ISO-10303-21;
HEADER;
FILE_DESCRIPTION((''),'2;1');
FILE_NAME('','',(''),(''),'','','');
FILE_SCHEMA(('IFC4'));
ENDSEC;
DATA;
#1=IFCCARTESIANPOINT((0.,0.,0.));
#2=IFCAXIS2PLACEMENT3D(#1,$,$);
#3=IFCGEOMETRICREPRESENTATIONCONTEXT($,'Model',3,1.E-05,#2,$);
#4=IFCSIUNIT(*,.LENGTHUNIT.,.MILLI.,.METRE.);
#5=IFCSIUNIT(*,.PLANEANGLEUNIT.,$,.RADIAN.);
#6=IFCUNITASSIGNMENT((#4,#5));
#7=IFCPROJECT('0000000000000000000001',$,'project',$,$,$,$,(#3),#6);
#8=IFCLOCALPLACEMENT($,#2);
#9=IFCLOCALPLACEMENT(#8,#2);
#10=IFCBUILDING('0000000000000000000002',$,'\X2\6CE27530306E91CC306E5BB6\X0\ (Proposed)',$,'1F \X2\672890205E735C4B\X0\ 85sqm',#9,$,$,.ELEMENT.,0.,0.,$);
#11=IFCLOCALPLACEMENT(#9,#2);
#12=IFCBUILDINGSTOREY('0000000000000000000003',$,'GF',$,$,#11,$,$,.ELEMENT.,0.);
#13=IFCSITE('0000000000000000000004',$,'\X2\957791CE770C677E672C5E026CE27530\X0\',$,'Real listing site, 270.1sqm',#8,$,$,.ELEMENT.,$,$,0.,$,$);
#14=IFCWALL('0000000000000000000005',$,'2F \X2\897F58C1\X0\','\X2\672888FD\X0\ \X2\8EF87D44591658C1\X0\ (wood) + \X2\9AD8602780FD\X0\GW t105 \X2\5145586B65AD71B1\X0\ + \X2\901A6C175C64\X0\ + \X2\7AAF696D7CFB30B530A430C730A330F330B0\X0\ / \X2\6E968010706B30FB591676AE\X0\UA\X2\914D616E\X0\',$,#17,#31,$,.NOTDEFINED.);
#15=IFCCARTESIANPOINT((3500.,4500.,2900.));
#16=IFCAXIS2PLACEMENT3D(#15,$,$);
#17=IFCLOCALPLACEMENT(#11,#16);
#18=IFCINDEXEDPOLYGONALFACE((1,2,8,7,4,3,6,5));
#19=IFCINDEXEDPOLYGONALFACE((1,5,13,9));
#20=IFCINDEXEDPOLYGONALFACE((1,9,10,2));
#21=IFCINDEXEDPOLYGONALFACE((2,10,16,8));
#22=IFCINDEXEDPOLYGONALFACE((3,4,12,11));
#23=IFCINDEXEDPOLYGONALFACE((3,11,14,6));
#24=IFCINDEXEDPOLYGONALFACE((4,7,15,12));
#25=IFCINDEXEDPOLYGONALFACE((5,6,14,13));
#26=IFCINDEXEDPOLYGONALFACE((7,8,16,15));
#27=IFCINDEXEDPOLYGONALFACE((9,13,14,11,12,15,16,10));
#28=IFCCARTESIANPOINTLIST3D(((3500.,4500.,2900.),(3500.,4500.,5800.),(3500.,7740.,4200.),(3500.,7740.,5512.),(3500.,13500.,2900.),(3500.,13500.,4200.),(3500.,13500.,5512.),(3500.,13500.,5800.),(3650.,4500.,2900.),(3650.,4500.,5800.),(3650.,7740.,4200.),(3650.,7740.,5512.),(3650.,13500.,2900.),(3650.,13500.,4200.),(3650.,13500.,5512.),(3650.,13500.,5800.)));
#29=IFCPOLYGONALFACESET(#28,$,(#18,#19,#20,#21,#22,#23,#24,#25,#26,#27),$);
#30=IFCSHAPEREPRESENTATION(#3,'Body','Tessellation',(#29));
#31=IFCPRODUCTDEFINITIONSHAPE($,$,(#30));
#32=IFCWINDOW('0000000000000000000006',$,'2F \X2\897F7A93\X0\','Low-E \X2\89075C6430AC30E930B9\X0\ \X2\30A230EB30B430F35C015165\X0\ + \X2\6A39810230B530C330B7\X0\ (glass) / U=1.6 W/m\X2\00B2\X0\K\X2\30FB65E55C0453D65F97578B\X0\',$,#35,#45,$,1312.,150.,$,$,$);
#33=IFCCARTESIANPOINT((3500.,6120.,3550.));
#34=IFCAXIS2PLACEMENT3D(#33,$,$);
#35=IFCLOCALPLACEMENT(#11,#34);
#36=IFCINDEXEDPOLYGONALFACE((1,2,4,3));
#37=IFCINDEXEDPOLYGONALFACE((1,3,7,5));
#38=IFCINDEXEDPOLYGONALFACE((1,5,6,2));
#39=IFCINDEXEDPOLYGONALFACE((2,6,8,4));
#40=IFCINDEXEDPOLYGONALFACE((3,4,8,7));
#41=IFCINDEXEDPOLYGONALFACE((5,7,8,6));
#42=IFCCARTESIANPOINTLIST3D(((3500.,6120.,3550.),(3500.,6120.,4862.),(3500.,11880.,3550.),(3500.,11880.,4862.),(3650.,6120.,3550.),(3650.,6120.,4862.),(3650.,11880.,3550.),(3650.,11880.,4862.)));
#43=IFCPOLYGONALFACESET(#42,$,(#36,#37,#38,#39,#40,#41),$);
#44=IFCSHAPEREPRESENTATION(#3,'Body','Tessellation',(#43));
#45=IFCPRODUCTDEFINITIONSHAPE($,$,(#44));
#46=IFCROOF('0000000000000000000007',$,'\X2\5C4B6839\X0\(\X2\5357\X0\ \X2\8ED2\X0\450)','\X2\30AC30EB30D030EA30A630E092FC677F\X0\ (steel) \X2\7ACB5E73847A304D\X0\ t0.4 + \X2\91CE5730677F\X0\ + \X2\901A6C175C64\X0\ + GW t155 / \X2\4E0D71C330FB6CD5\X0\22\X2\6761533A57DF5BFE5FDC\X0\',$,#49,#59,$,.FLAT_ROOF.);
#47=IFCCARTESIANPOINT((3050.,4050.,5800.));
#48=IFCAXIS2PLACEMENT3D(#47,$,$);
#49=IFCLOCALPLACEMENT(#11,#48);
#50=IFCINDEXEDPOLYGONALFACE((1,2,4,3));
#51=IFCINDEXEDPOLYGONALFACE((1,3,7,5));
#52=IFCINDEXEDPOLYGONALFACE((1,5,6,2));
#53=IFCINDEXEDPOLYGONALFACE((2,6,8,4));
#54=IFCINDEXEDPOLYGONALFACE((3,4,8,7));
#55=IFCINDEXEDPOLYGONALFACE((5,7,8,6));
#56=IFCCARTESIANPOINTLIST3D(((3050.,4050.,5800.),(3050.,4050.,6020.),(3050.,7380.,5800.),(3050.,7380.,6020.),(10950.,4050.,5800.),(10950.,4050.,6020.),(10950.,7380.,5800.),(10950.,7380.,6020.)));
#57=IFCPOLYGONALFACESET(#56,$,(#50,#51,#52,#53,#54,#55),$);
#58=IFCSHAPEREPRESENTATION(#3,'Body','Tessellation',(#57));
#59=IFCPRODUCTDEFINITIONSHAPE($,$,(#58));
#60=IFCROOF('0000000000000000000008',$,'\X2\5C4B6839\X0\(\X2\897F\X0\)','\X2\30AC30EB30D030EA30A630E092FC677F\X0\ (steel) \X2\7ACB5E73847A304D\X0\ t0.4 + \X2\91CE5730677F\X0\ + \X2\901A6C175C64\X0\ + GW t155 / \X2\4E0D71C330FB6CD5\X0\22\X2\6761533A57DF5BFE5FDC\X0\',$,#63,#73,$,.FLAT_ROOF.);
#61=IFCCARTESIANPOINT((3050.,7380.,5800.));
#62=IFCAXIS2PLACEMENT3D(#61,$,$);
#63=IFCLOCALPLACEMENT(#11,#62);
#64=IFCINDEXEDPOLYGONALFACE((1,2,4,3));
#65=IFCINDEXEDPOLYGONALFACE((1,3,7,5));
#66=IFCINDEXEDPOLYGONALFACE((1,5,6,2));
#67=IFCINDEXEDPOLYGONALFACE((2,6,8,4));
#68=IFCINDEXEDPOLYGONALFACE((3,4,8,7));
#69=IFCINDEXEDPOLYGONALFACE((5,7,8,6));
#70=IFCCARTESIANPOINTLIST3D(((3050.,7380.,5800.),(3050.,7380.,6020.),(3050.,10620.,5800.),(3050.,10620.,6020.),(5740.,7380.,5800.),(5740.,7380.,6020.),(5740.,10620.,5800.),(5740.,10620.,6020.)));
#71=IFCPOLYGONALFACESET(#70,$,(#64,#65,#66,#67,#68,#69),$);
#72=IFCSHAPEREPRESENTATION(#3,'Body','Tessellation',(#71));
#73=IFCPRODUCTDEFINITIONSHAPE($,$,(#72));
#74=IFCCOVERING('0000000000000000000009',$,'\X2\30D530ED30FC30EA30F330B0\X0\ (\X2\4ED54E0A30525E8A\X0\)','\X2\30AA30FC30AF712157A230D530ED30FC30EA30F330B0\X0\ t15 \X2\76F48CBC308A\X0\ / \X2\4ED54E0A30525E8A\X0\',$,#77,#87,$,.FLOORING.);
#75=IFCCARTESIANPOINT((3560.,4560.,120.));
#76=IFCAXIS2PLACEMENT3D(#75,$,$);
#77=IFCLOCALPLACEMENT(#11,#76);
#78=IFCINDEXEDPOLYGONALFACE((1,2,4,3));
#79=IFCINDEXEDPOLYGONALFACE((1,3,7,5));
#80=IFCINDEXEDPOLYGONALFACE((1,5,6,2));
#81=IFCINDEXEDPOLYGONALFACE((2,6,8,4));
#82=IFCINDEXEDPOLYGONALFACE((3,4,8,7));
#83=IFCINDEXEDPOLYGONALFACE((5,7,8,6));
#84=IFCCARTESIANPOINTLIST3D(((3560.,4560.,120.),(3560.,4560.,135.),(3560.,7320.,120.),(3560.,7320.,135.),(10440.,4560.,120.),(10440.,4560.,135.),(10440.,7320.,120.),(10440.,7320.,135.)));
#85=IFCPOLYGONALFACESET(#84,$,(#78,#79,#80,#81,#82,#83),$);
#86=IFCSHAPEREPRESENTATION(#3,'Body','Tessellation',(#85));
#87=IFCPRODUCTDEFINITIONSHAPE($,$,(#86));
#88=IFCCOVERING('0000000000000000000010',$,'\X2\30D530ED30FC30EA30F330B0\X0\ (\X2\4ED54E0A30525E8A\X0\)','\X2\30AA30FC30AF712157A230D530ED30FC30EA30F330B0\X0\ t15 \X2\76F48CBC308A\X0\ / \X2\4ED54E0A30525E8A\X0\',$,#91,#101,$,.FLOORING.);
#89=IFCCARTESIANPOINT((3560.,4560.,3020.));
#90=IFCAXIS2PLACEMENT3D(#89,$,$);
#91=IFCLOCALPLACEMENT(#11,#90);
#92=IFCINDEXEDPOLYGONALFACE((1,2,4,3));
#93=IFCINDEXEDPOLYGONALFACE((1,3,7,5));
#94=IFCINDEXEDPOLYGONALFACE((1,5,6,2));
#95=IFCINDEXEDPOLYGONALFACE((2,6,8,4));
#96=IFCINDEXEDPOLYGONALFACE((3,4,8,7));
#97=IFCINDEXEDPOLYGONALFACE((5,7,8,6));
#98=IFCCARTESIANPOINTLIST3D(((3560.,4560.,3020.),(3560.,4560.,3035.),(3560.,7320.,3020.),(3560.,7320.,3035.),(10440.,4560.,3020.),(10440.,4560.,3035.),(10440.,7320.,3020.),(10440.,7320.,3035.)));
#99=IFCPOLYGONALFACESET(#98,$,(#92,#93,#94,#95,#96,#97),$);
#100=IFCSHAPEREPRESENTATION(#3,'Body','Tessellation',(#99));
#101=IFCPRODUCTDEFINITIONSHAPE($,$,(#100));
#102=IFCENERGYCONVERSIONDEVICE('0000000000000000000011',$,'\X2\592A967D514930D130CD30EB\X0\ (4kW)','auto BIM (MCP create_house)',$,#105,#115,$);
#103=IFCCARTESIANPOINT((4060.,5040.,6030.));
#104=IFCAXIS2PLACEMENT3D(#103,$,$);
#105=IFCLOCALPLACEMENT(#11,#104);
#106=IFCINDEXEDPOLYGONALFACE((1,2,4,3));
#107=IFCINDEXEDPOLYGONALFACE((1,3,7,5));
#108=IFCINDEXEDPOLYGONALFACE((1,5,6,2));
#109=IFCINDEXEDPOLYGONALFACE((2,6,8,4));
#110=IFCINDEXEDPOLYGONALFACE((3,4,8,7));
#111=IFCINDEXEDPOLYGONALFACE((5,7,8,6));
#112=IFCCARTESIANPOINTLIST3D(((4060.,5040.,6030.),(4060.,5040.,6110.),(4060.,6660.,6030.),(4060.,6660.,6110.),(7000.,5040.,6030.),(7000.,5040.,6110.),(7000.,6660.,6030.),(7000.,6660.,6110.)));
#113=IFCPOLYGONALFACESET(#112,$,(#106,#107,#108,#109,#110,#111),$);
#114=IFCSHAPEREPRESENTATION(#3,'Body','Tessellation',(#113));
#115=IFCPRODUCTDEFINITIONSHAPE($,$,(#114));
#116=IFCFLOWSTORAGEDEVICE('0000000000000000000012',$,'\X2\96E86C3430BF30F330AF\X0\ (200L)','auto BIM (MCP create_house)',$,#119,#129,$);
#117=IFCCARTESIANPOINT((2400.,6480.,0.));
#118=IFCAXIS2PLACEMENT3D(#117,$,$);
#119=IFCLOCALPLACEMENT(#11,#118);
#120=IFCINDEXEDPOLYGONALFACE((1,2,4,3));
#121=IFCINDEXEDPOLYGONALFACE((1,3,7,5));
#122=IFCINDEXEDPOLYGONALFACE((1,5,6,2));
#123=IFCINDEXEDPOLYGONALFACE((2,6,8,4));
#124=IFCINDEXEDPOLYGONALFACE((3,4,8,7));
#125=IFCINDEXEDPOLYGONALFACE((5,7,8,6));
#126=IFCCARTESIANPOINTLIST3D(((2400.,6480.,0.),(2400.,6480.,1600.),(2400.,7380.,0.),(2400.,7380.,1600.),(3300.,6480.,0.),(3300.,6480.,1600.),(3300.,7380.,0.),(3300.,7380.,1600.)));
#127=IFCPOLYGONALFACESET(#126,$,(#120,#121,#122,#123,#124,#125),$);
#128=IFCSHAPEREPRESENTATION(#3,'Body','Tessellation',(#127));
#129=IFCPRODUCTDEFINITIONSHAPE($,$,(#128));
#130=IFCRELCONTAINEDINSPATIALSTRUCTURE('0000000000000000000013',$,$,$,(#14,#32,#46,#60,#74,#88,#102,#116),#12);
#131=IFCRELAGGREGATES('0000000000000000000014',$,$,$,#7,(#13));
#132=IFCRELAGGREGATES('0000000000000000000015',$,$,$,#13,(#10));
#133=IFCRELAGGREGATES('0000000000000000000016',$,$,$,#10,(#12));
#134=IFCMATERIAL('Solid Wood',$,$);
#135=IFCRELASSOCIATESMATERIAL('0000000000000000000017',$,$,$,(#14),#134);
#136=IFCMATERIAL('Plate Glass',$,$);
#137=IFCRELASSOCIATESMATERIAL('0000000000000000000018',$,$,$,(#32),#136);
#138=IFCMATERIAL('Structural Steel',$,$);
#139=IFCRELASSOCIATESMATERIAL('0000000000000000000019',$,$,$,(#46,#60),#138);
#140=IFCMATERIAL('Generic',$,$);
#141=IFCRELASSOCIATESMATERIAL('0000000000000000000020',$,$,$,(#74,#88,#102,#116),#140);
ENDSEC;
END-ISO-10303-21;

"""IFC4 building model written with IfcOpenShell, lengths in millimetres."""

from ifc_helpers import new_model, si_unit, frame, frame_2d, origin, place, context, project, spatial, rectangle, extrude, material, element, fill, save


model = new_model("IFC4")

# Units and contexts
model_context = context("Model", 3, precision=1e-05, world=origin())
ifc_project = project(units=[si_unit("LENGTHUNIT", "METRE", prefix="MILLI"), si_unit("PLANEANGLEUNIT", "RADIAN")], contexts=[model_context])

# Site, building, storey
site_placement = place(None, origin())
site = spatial("IfcSite", under=ifc_project, at=site_placement, Name="長野県松本市波田", ObjectType="Real listing site, 270.1sqm", CompositionType="ELEMENT", RefElevation=0.0)
building_placement = place(site_placement, origin())
building = spatial("IfcBuilding", under=site, at=building_placement, Name="波田の里の家 (Proposed)", ObjectType="1F 木造平屋 85sqm", CompositionType="ELEMENT", ElevationOfRefHeight=0.0, ElevationOfTerrain=0.0)
storey_placement = place(building_placement, origin())
storey = spatial("IfcBuildingStorey", under=building, at=storey_placement, Name="GF", CompositionType="ELEMENT", Elevation=0.0)

# Shared definitions
ifc_material_1 = material(Name="Solid Wood")
ifc_material_2 = material(Name="Generic")

# Shared definitions
ifc_material_3 = material(Name="Plate Glass")

# Wall, opening, window
wall_1_placement = place(storey_placement, frame((3500.0, 4500.0, 2900.0)))
wall_1 = element("IfcWall", 1, at=wall_1_placement, inside=storey, material=ifc_material_1, Name="2F 西壁", Description="木製 軸組外壁 (wood) + 高性能GW t105 充填断熱 + 通気層 + 窯業系サイディング / 準耐火・外皮UA配慮", PredefinedType="NOTDEFINED", context=model_context, shape_type="SweptSolid", body=[
    extrude(rectangle(XDim=150.0, YDim=9000.0, at=frame_2d((75.0, 4500.0))), frame((3500.0, 4500.0, 2900.0)), (0.0, 0.0, 1.0), 2900.0),
])
opening_1_placement = place(storey_placement, frame((3500.0, 6120.0, 3550.0)))
opening_1 = element("IfcOpeningElement", 2, at=opening_1_placement, cuts=wall_1, PredefinedType="NOTDEFINED", context=model_context, shape_type="SweptSolid", body=[
    extrude(rectangle(XDim=150.0, YDim=5760.0, at=frame_2d((75.0, 2880.0))), frame((3500.0, 6120.0, 3550.0)), (0.0, 0.0, 1.0), 1312.0),
])
window_1_placement = place(storey_placement, frame((3500.0, 6120.0, 3550.0)))
window_1 = element("IfcWindow", 3, at=window_1_placement, inside=storey, material=ifc_material_3, Name="2F 西窓", Description="Low-E 複層ガラス アルゴン封入 + 樹脂サッシ (glass) / U=1.6 W/m²K・日射取得型", OverallHeight=1312.0, OverallWidth=150.0, context=model_context, shape_type="SweptSolid", body=[
    extrude(rectangle(XDim=150.0, YDim=5760.0, at=frame_2d((75.0, 2880.0))), frame((3500.0, 6120.0, 3550.0)), (0.0, 0.0, 1.0), 1312.0),
])
fill(opening_1, window_1)

# Roofs
ifc_material_4 = material(Name="Structural Steel")
roof_1_placement = place(storey_placement, frame((3050.0, 4050.0, 5800.0)))
element("IfcRoof", 4, at=roof_1_placement, inside=storey, material=ifc_material_4, Name="屋根(南 軒450)", Description="ガルバリウム鋼板 (steel) 立平葺き t0.4 + 野地板 + 通気層 + GW t155 / 不燃・法22条区域対応", PredefinedType="FLAT_ROOF", context=model_context, shape_type="SweptSolid", body=[
    extrude(rectangle(XDim=7900.0, YDim=3330.0, at=frame_2d((3950.0, 1665.0))), frame((3050.0, 4050.0, 5800.0)), (0.0, 0.0, 1.0), 220.0),
])
roof_2_placement = place(storey_placement, frame((3050.0, 7380.0, 5800.0)))
element("IfcRoof", 5, at=roof_2_placement, inside=storey, material=ifc_material_4, Name="屋根(西)", Description="ガルバリウム鋼板 (steel) 立平葺き t0.4 + 野地板 + 通気層 + GW t155 / 不燃・法22条区域対応", PredefinedType="FLAT_ROOF", context=model_context, shape_type="SweptSolid", body=[
    extrude(rectangle(XDim=2690.0, YDim=3240.0, at=frame_2d((1345.0, 1620.0))), frame((3050.0, 7380.0, 5800.0)), (0.0, 0.0, 1.0), 220.0),
])

# Coverings
covering_1_placement = place(storey_placement, frame((3560.0, 4560.0, 120.0)))
element("IfcCovering", 6, at=covering_1_placement, inside=storey, material=ifc_material_2, Name="フローリング (仕上げ床)", Description="オーク無垢フローリング t15 直貼り / 仕上げ床", PredefinedType="FLOORING", context=model_context, shape_type="SweptSolid", body=[
    extrude(rectangle(XDim=6880.0, YDim=2760.0, at=frame_2d((3440.0, 1380.0))), frame((3560.0, 4560.0, 120.0)), (0.0, 0.0, 1.0), 15.0),
])
covering_2_placement = place(storey_placement, frame((3560.0, 4560.0, 3020.0)))
element("IfcCovering", 7, at=covering_2_placement, inside=storey, material=ifc_material_2, Name="フローリング (仕上げ床)", Description="オーク無垢フローリング t15 直貼り / 仕上げ床", PredefinedType="FLOORING", context=model_context, shape_type="SweptSolid", body=[
    extrude(rectangle(XDim=6880.0, YDim=2760.0, at=frame_2d((3440.0, 1380.0))), frame((3560.0, 4560.0, 3020.0)), (0.0, 0.0, 1.0), 15.0),
])

# Energy conversion device
energy_conversion_device_placement = place(storey_placement, frame((4060.0, 5040.0, 6030.0)))
element("IfcEnergyConversionDevice", 8, at=energy_conversion_device_placement, inside=storey, material=ifc_material_2, Name="太陽光パネル (4kW)", Description="auto BIM (MCP create_house)", context=model_context, shape_type="SweptSolid", body=[
    extrude(rectangle(XDim=2940.0, YDim=1620.0, at=frame_2d((1470.0, 810.0))), frame((4060.0, 5040.0, 6030.0)), (0.0, 0.0, 1.0), 80.0),
])

# Flow storage device
flow_storage_device_placement = place(storey_placement, frame((2400.0, 6480.0, 0.0)))
element("IfcFlowStorageDevice", 9, at=flow_storage_device_placement, inside=storey, material=ifc_material_2, Name="雨水タンク (200L)", Description="auto BIM (MCP create_house)", context=model_context, shape_type="SweptSolid", body=[
    extrude(rectangle(XDim=900.0, YDim=900.0, at=frame_2d((450.0, 450.0))), frame((2400.0, 6480.0, 0.0)), (0.0, 0.0, 1.0), 1600.0),
])

save(model, "model.ifc")
